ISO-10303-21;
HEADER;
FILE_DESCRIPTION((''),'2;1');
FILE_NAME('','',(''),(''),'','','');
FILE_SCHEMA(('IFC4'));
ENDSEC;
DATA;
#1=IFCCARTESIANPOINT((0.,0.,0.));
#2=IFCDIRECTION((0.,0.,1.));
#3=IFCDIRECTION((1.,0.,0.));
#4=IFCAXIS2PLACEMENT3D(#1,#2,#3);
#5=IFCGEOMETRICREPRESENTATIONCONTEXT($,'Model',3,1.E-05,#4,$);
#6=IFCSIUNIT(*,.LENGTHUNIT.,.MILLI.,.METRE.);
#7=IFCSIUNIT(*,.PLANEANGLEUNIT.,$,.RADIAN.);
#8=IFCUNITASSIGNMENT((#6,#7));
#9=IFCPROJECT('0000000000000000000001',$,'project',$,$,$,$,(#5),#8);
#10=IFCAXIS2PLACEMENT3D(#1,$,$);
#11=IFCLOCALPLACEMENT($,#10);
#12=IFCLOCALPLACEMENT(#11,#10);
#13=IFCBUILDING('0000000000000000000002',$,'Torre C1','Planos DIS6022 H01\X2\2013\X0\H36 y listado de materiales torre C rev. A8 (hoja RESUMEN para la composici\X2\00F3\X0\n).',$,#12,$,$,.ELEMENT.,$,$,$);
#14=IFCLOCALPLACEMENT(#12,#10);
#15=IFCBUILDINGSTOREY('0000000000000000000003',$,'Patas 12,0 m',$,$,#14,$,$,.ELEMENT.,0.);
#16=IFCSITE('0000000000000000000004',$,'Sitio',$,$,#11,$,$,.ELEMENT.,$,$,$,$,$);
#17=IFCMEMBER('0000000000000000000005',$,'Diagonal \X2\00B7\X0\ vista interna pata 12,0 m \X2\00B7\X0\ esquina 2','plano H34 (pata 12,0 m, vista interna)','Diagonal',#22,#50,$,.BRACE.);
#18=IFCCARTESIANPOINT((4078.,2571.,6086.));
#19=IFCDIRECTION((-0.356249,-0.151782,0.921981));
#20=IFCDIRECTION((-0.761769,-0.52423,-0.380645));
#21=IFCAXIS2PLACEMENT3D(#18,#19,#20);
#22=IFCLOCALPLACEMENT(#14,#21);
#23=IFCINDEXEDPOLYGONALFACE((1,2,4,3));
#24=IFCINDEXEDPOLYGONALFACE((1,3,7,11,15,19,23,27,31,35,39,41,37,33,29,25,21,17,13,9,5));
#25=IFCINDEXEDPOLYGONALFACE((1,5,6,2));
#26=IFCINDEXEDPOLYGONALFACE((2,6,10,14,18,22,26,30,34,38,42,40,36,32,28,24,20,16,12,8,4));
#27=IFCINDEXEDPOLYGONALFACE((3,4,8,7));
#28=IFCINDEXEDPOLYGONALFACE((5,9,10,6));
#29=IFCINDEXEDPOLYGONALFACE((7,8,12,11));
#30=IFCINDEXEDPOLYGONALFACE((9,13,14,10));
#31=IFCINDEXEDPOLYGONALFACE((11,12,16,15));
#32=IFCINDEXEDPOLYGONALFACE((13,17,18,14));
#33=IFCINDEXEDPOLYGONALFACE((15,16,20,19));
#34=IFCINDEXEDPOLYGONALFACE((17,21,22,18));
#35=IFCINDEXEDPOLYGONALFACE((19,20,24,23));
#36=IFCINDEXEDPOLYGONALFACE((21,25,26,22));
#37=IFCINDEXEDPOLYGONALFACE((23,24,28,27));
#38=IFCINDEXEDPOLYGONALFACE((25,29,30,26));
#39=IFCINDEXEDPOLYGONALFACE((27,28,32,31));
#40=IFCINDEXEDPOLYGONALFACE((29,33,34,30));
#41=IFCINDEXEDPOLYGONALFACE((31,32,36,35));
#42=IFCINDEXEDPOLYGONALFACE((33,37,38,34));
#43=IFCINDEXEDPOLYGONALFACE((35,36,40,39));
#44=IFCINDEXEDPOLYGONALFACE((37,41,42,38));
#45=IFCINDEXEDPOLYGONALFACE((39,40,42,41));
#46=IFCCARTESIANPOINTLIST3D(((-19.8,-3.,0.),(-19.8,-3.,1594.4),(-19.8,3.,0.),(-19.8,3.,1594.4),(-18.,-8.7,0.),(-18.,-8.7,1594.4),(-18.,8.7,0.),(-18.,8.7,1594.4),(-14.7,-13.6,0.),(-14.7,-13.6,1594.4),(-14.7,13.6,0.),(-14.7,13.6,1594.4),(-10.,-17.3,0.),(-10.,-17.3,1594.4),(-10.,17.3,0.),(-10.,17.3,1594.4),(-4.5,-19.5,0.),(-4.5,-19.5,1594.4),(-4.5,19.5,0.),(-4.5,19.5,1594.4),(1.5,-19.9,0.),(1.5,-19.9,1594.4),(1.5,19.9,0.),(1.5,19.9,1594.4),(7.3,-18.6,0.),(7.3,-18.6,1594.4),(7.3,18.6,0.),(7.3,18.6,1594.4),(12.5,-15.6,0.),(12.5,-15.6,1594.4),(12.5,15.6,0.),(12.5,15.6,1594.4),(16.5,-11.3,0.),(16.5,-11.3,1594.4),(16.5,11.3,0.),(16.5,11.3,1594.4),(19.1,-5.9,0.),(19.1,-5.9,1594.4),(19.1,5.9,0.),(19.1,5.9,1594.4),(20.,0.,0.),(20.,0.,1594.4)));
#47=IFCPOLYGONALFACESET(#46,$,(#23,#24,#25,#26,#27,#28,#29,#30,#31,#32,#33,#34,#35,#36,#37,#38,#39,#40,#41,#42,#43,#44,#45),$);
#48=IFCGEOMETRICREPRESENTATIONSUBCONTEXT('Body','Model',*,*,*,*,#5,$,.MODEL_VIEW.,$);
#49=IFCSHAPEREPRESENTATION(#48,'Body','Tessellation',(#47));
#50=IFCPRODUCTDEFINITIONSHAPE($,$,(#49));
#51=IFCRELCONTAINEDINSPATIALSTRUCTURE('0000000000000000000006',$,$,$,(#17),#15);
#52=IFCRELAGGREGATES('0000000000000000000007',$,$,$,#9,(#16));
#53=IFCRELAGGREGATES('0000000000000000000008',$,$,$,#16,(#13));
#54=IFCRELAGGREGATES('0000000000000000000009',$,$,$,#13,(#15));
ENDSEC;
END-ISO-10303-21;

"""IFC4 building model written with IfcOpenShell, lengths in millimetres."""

from ifc_helpers import new_model, si_unit, frame, origin, origin_with_axes, place, context, subcontext, project, spatial, circle, extrude, element, save


model = new_model("IFC4")

# Units and contexts
model_context = context("Model", 3, precision=1e-05, world=origin_with_axes())
body_context = subcontext(model_context, "Body", "Model", "MODEL_VIEW")
ifc_project = project(units=[si_unit("LENGTHUNIT", "METRE", prefix="MILLI"), si_unit("PLANEANGLEUNIT", "RADIAN")], contexts=[model_context])

# Site, building, storey
site_placement = place(None, origin())
site = spatial("IfcSite", under=ifc_project, at=site_placement, Name="Sitio", CompositionType="ELEMENT")
building_placement = place(site_placement, origin())
building = spatial("IfcBuilding", under=site, at=building_placement, Name="Torre C1", Description="Planos DIS6022 H01–H36 y listado de materiales torre C rev. A8 (hoja RESUMEN para la composición).", CompositionType="ELEMENT")
storey_placement = place(building_placement, origin())
storey = spatial("IfcBuildingStorey", under=building, at=storey_placement, Name="Patas 12,0 m", CompositionType="ELEMENT", Elevation=0.0)

# Member
member_1_placement = place(storey_placement, frame((4078.0, 2571.0, 6086.0), z_axis=(-0.356249, -0.151782, 0.921981), x_axis=(-0.761769, -0.52423, -0.380645)))
element("IfcMember", 1, at=member_1_placement, inside=storey, Name="Diagonal · vista interna pata 12,0 m · esquina 2", Description="plano H34 (pata 12,0 m, vista interna)", ObjectType="Diagonal", PredefinedType="BRACE", context=body_context, shape_type="SweptSolid", body=[
    extrude(circle(Radius=20.0), None, (0.0, 0.0, 1.0), 1594.4),
])

save(model, "model.ifc")
